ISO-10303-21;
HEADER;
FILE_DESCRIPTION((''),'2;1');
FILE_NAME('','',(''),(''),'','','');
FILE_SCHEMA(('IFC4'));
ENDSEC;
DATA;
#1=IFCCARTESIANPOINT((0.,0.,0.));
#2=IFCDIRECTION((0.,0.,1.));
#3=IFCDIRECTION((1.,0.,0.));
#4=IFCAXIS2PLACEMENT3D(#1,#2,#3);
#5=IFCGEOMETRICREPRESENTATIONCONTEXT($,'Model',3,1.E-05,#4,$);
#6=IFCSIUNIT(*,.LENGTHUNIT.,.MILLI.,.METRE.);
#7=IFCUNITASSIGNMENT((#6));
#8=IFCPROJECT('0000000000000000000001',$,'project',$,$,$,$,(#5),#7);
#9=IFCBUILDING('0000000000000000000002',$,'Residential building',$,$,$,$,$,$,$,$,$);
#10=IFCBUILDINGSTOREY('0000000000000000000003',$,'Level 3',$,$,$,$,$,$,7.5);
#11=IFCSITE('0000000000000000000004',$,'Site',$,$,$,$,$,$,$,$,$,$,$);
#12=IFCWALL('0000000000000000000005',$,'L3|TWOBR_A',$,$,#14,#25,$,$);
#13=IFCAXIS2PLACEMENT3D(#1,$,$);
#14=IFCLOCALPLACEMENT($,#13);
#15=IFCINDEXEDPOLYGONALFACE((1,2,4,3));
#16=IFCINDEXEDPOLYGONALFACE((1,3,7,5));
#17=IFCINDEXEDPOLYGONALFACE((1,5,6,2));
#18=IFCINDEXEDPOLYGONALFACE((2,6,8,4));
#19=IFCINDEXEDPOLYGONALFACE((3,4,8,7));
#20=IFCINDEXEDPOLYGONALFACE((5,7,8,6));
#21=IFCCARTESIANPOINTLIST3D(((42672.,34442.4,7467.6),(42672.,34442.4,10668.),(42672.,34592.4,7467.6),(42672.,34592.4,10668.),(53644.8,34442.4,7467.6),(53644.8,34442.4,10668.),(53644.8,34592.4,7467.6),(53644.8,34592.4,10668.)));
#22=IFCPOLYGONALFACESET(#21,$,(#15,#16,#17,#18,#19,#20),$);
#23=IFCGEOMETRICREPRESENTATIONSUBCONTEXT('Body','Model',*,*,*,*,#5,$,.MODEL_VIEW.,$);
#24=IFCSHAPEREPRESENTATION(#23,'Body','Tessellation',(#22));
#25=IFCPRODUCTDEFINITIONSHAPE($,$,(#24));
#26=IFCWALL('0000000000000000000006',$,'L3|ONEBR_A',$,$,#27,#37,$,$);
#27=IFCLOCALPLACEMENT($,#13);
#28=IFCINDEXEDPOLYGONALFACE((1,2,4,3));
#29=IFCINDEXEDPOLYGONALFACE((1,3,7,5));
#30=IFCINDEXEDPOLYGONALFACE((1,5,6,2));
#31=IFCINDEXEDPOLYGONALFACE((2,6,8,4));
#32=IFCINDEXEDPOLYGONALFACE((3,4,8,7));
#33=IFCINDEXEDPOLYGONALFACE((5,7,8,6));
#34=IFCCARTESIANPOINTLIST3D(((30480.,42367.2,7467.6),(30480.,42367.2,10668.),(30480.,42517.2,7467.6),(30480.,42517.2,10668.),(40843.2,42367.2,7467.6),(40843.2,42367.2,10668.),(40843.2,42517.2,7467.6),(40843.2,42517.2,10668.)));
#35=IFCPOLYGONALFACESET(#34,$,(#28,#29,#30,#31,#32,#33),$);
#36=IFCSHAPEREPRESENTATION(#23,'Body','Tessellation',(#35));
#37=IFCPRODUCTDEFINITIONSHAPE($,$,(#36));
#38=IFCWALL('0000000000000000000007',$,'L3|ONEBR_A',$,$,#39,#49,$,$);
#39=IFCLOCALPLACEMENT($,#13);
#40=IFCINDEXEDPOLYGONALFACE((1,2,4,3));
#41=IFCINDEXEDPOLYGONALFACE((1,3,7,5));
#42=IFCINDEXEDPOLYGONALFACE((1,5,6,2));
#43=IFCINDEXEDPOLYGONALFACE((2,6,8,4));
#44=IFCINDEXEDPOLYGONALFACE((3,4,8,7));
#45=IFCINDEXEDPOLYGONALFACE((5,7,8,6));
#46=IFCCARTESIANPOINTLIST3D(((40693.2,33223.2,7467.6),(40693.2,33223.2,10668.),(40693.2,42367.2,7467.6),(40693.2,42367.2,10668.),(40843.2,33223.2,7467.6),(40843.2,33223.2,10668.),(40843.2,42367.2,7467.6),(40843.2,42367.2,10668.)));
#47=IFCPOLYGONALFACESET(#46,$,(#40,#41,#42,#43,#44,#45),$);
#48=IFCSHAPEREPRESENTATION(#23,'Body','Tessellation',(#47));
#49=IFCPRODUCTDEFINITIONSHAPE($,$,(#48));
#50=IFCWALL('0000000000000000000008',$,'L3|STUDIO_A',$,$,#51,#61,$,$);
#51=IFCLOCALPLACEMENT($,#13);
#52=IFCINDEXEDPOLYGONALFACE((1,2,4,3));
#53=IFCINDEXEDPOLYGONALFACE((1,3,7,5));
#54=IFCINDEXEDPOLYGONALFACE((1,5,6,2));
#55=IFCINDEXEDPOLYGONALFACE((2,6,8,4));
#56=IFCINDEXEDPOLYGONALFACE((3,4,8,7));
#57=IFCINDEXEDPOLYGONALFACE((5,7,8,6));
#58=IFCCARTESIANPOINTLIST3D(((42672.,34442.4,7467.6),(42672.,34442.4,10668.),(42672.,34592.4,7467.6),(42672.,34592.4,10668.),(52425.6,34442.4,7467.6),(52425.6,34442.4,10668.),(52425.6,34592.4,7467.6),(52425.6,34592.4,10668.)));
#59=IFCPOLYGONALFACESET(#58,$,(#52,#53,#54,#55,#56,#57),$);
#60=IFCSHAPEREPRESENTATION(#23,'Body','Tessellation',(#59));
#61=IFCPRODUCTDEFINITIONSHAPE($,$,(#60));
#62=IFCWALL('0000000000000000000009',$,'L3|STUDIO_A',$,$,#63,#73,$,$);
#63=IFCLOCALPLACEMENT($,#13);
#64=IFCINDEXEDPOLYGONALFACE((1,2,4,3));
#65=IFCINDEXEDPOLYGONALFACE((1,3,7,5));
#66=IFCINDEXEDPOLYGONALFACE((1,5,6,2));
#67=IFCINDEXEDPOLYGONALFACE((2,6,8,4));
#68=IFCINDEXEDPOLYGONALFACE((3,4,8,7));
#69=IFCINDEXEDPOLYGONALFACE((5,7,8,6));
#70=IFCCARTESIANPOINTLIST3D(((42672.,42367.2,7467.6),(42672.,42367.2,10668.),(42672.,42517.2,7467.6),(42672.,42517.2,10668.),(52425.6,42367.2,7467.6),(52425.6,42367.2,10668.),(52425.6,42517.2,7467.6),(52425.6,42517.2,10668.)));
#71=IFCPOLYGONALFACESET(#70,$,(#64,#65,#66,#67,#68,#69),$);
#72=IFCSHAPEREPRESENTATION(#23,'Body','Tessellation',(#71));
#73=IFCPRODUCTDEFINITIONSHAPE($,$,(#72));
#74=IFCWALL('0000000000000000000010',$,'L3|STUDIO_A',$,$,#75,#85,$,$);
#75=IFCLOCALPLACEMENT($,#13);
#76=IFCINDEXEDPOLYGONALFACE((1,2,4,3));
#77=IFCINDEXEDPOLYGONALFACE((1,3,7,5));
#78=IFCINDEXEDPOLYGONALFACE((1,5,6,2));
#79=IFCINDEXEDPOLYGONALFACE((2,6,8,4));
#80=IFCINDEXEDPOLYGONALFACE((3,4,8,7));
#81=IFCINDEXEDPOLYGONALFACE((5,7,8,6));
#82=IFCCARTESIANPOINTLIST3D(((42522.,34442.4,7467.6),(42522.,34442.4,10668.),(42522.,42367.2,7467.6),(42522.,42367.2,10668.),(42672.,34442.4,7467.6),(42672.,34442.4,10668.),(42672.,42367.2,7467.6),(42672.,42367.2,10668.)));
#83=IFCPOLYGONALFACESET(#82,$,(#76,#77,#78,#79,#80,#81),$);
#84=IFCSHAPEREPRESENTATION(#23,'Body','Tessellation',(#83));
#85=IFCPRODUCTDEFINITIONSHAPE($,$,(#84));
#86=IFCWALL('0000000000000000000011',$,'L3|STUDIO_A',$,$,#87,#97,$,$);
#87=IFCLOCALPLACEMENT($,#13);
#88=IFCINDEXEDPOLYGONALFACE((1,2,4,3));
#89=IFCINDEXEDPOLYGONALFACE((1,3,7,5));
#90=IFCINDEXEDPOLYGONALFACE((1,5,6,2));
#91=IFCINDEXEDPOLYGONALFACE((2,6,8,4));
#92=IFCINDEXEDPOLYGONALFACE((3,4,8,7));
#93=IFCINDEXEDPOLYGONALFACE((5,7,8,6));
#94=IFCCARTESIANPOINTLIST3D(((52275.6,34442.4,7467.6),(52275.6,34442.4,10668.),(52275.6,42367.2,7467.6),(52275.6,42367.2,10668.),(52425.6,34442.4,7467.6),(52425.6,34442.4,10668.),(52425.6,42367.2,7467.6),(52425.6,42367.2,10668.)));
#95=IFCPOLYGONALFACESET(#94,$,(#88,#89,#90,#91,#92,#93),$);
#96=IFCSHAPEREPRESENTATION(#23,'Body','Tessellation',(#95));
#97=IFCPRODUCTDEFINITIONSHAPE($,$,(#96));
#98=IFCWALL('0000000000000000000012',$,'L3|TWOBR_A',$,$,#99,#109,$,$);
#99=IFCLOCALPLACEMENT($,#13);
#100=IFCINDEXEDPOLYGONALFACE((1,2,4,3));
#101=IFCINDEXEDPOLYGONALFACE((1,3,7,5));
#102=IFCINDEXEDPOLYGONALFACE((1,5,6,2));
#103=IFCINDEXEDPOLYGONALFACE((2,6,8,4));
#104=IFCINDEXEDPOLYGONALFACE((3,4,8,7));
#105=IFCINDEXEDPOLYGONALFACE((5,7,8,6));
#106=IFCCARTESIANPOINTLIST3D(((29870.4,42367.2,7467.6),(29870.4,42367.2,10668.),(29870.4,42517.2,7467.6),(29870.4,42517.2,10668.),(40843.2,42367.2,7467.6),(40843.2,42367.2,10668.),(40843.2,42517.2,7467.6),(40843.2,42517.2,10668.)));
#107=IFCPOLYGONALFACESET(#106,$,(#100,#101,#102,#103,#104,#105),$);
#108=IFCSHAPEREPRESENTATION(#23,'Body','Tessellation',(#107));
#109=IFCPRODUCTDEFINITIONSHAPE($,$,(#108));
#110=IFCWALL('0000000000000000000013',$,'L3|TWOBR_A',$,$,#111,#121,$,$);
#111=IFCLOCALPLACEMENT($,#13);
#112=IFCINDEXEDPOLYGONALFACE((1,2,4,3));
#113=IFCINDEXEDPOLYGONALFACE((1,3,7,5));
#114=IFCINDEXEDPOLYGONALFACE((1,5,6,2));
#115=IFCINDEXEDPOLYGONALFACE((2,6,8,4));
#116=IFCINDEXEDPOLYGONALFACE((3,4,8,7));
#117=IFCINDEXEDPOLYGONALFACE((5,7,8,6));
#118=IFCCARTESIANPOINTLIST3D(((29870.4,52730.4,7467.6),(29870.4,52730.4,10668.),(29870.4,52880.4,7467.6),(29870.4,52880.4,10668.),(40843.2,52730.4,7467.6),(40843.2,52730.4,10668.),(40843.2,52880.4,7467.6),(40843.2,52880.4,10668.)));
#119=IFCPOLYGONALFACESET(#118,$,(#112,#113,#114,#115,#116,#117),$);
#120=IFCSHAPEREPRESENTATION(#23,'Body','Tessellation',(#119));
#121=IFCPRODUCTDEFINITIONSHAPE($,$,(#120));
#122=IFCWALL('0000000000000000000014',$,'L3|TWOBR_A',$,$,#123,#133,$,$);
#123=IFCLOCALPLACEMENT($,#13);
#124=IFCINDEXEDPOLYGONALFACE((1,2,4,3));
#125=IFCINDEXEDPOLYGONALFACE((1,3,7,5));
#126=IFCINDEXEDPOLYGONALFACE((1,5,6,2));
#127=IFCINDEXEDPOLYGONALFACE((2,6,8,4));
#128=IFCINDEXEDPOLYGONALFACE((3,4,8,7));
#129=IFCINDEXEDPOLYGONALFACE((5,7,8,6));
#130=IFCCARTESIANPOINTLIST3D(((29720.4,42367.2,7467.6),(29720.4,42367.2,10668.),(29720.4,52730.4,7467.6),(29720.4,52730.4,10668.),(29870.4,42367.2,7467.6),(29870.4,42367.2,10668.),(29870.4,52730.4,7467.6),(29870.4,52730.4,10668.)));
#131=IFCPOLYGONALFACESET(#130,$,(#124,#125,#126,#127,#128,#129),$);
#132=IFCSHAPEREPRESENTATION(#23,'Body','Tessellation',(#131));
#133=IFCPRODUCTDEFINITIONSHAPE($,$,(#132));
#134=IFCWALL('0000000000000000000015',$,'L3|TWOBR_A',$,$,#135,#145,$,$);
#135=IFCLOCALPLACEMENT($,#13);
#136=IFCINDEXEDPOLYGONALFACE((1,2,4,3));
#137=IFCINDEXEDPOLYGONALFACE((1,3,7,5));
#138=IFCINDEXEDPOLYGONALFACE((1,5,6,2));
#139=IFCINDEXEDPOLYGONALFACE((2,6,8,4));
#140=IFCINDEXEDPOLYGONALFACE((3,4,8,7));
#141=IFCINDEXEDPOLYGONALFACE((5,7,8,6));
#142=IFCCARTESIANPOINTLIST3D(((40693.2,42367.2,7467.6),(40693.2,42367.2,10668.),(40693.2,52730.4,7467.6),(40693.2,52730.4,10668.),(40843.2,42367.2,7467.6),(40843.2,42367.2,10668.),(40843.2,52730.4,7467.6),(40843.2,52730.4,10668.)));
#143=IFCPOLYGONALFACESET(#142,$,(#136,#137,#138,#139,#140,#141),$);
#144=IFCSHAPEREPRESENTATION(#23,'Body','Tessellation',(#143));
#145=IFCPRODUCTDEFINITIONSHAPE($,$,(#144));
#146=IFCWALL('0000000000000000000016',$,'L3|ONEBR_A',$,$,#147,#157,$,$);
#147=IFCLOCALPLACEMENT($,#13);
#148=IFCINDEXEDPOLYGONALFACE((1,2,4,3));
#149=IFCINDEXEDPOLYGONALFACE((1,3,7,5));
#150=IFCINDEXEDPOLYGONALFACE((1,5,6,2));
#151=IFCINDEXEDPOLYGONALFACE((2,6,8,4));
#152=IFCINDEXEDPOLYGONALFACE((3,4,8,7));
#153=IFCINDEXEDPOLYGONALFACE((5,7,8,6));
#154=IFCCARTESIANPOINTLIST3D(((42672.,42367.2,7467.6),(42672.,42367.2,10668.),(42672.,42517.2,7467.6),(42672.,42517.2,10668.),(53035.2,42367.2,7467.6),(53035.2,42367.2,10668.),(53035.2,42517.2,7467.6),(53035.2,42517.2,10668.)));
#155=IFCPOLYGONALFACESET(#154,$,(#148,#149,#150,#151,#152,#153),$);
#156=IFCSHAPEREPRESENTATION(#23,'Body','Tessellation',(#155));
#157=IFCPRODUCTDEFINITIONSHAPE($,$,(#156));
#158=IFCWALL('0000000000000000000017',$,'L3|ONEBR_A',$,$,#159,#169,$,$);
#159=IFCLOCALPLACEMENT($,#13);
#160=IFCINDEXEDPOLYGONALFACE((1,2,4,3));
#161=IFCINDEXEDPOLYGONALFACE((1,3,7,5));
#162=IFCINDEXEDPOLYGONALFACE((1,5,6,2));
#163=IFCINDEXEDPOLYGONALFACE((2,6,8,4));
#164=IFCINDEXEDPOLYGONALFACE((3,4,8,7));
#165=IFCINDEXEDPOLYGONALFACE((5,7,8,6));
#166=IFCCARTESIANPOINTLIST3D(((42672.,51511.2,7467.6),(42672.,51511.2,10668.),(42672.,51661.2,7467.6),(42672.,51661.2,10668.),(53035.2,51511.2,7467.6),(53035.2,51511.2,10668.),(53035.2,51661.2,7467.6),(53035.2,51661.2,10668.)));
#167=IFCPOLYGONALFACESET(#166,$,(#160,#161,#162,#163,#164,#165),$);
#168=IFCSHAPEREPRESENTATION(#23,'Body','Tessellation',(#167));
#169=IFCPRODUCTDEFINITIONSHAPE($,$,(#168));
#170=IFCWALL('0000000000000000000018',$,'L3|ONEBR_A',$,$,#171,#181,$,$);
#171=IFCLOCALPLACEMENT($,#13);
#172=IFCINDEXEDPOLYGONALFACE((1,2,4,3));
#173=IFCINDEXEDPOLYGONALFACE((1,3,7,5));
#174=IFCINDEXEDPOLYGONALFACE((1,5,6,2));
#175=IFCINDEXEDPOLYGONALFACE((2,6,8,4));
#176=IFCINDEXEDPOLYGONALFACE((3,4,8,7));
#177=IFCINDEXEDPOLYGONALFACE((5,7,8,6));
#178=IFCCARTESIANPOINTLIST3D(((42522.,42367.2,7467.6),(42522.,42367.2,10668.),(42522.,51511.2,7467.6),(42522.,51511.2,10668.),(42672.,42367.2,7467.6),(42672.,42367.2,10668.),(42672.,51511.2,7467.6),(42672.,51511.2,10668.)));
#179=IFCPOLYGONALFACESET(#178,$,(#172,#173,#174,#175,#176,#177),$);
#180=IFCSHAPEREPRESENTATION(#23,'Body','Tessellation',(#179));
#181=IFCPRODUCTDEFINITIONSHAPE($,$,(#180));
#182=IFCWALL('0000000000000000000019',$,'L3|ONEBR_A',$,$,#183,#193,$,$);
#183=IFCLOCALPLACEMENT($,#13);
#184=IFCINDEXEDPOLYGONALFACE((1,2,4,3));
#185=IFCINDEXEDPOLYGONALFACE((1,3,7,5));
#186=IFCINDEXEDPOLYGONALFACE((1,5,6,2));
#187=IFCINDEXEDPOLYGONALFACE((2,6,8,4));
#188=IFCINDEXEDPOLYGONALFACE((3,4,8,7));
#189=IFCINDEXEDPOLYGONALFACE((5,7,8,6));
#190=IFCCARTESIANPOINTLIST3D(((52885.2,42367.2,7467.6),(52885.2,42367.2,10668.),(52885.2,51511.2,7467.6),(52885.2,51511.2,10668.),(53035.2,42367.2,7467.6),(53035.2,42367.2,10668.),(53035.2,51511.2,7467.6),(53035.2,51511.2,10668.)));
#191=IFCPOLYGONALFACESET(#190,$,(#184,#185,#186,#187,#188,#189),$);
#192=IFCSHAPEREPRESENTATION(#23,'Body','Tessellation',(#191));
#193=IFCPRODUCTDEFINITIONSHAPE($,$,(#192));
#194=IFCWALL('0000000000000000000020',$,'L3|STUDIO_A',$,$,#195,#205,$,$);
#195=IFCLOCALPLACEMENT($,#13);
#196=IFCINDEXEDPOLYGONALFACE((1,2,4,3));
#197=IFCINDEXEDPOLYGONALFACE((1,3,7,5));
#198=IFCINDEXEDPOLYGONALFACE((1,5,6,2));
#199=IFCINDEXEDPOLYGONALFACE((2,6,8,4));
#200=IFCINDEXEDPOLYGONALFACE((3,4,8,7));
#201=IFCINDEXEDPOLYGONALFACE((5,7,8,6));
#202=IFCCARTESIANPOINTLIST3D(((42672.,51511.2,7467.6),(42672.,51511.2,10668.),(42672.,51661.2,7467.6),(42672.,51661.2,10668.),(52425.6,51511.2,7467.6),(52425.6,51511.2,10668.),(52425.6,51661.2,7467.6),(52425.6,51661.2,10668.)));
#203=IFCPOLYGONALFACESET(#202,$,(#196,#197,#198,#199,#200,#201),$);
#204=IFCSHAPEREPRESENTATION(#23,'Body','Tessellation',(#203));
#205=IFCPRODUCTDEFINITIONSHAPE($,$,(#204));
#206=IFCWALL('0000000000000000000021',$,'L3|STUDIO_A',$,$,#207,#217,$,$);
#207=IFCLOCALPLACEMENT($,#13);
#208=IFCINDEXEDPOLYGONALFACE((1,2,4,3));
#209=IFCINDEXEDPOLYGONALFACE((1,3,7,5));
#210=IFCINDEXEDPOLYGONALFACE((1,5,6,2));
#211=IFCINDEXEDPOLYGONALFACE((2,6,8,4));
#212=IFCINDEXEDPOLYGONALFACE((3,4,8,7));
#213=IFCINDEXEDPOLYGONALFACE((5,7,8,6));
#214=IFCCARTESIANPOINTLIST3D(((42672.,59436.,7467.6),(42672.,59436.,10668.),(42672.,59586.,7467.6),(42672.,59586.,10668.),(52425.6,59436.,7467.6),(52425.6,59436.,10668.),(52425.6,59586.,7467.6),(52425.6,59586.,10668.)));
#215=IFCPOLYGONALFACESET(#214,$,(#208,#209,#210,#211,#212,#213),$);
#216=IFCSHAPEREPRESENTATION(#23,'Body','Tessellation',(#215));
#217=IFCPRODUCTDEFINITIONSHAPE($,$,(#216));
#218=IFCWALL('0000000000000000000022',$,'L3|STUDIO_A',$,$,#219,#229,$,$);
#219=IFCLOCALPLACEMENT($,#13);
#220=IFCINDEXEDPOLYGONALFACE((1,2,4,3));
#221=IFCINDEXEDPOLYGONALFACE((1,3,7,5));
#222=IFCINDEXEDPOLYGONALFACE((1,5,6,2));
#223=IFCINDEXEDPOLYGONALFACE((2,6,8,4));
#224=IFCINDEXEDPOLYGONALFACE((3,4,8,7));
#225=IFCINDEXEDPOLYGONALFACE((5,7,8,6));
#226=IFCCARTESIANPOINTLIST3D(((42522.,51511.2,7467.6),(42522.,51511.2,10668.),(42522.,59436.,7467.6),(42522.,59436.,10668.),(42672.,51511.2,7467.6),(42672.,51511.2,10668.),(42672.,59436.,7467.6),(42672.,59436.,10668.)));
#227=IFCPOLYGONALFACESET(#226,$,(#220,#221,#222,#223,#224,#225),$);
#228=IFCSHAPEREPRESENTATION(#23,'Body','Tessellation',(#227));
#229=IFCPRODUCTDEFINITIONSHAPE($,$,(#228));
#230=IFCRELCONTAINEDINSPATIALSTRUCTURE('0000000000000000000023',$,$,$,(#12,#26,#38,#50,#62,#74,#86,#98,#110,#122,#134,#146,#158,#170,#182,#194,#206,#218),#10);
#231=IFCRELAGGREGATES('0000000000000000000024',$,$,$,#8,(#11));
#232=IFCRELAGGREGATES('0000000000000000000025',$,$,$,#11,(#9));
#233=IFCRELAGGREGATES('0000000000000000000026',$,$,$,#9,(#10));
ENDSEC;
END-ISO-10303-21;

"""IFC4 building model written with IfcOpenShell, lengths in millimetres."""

from ifc_helpers import new_model, si_unit, frame, origin_with_axes, place, context, subcontext, project, spatial, indexed_curve, outline, extrude, element, save


model = new_model("IFC4")

# Units and contexts
model_context = context("Model", 3, precision=1e-05, world=origin_with_axes())
body_context = subcontext(model_context, "Body", "Model", "MODEL_VIEW")
ifc_project = project(units=[si_unit("LENGTHUNIT", "METRE", prefix="MILLI")], contexts=[model_context])

# Site, building, storey
site = spatial("IfcSite", under=ifc_project, Name="Site")
building = spatial("IfcBuilding", under=site, Name="Residential building")
storey = spatial("IfcBuildingStorey", under=building, Name="Level 3", Elevation=7.5)

# Walls
wall_1_placement = place(None, frame((42672.0, 34442.4, 7467.6), z_axis=(0.0, 0.0, 1.0), x_axis=(1.0, 0.0, 0.0)))
element("IfcWall", 1, at=wall_1_placement, inside=storey, Name="L3|TWOBR_A", context=body_context, shape_type="SweptSolid", body=[
    extrude(outline(indexed_curve([(0.0, 0.0), (0.0, 150.0), (10972.8, 150.0), (10972.8, 0.0), (0.0, 0.0)], self_intersect=False)), origin_with_axes(), (0.0, 0.0, 1.0), 3200.4),
])
wall_2_placement = place(None, frame((30480.0, 42367.2, 7467.6), z_axis=(0.0, 0.0, 1.0), x_axis=(1.0, 0.0, 0.0)))
element("IfcWall", 2, at=wall_2_placement, inside=storey, Name="L3|ONEBR_A", context=body_context, shape_type="SweptSolid", body=[
    extrude(outline(indexed_curve([(0.0, 0.0), (0.0, 150.0), (10363.2, 150.0), (10363.2, 0.0), (0.0, 0.0)], self_intersect=False)), origin_with_axes(), (0.0, 0.0, 1.0), 3200.4),
])
wall_3_placement = place(None, frame((40843.2, 33223.2, 7467.6), z_axis=(0.0, 0.0, 1.0), x_axis=(0.0, 1.0, 0.0)))
element("IfcWall", 3, at=wall_3_placement, inside=storey, Name="L3|ONEBR_A", context=body_context, shape_type="SweptSolid", body=[
    extrude(outline(indexed_curve([(0.0, 0.0), (0.0, 150.0), (9144.0, 150.0), (9144.0, 0.0), (0.0, 0.0)], self_intersect=False)), origin_with_axes(), (0.0, 0.0, 1.0), 3200.4),
])
for number, where, z_axis, x_axis, name in (
    (4, (42672.0, 34442.4, 7467.6), (0.0, 0.0, 1.0), (1.0, 0.0, 0.0), "L3|STUDIO_A"),
    (5, (42672.0, 42367.2, 7467.6), (0.0, 0.0, 1.0), (1.0, 0.0, 0.0), "L3|STUDIO_A"),
):
    element("IfcWall", number, at=place(None, frame(where, z_axis=z_axis, x_axis=x_axis)), inside=storey, Name=name, context=body_context, shape_type="SweptSolid", body=[
        extrude(outline(indexed_curve([(0.0, 0.0), (0.0, 150.0), (9753.6, 150.0), (9753.6, 0.0), (0.0, 0.0)], self_intersect=False)), origin_with_axes(), (0.0, 0.0, 1.0), 3200.4),
    ])
for number, where, z_axis, x_axis, name in (
    (6, (42672.0, 34442.4, 7467.6), (0.0, 0.0, 1.0), (0.0, 1.0, 0.0), "L3|STUDIO_A"),
    (7, (52425.6, 34442.4, 7467.6), (0.0, 0.0, 1.0), (0.0, 1.0, 0.0), "L3|STUDIO_A"),
):
    element("IfcWall", number, at=place(None, frame(where, z_axis=z_axis, x_axis=x_axis)), inside=storey, Name=name, context=body_context, shape_type="SweptSolid", body=[
        extrude(outline(indexed_curve([(0.0, 0.0), (0.0, 150.0), (7924.8, 150.0), (7924.8, 0.0), (0.0, 0.0)], self_intersect=False)), origin_with_axes(), (0.0, 0.0, 1.0), 3200.4),
    ])
for number, where, z_axis, x_axis, name in (
    (8, (29870.4, 42367.2, 7467.6), (0.0, 0.0, 1.0), (1.0, 0.0, 0.0), "L3|TWOBR_A"),
    (9, (29870.4, 52730.4, 7467.6), (0.0, 0.0, 1.0), (1.0, 0.0, 0.0), "L3|TWOBR_A"),
):
    element("IfcWall", number, at=place(None, frame(where, z_axis=z_axis, x_axis=x_axis)), inside=storey, Name=name, context=body_context, shape_type="SweptSolid", body=[
        extrude(outline(indexed_curve([(0.0, 0.0), (0.0, 150.0), (10972.8, 150.0), (10972.8, 0.0), (0.0, 0.0)], self_intersect=False)), origin_with_axes(), (0.0, 0.0, 1.0), 3200.4),
    ])
for number, where, z_axis, x_axis, name in (
    (10, (29870.4, 42367.2, 7467.6), (0.0, 0.0, 1.0), (0.0, 1.0, 0.0), "L3|TWOBR_A"),
    (11, (40843.2, 42367.2, 7467.6), (0.0, 0.0, 1.0), (0.0, 1.0, 0.0), "L3|TWOBR_A"),
    (12, (42672.0, 42367.2, 7467.6), (0.0, 0.0, 1.0), (1.0, 0.0, 0.0), "L3|ONEBR_A"),
    (13, (42672.0, 51511.2, 7467.6), (0.0, 0.0, 1.0), (1.0, 0.0, 0.0), "L3|ONEBR_A"),
):
    element("IfcWall", number, at=place(None, frame(where, z_axis=z_axis, x_axis=x_axis)), inside=storey, Name=name, context=body_context, shape_type="SweptSolid", body=[
        extrude(outline(indexed_curve([(0.0, 0.0), (0.0, 150.0), (10363.2, 150.0), (10363.2, 0.0), (0.0, 0.0)], self_intersect=False)), origin_with_axes(), (0.0, 0.0, 1.0), 3200.4),
    ])
for number, where, z_axis, x_axis, name in (
    (14, (42672.0, 42367.2, 7467.6), (0.0, 0.0, 1.0), (0.0, 1.0, 0.0), "L3|ONEBR_A"),
    (15, (53035.2, 42367.2, 7467.6), (0.0, 0.0, 1.0), (0.0, 1.0, 0.0), "L3|ONEBR_A"),
):
    element("IfcWall", number, at=place(None, frame(where, z_axis=z_axis, x_axis=x_axis)), inside=storey, Name=name, context=body_context, shape_type="SweptSolid", body=[
        extrude(outline(indexed_curve([(0.0, 0.0), (0.0, 150.0), (9144.0, 150.0), (9144.0, 0.0), (0.0, 0.0)], self_intersect=False)), origin_with_axes(), (0.0, 0.0, 1.0), 3200.4),
    ])
for number, where, z_axis, x_axis, name in (
    (16, (42672.0, 51511.2, 7467.6), (0.0, 0.0, 1.0), (1.0, 0.0, 0.0), "L3|STUDIO_A"),
    (17, (42672.0, 59436.0, 7467.6), (0.0, 0.0, 1.0), (1.0, 0.0, 0.0), "L3|STUDIO_A"),
):
    element("IfcWall", number, at=place(None, frame(where, z_axis=z_axis, x_axis=x_axis)), inside=storey, Name=name, context=body_context, shape_type="SweptSolid", body=[
        extrude(outline(indexed_curve([(0.0, 0.0), (0.0, 150.0), (9753.6, 150.0), (9753.6, 0.0), (0.0, 0.0)], self_intersect=False)), origin_with_axes(), (0.0, 0.0, 1.0), 3200.4),
    ])
for number, where, z_axis, x_axis, name in (
    (18, (42672.0, 51511.2, 7467.6), (0.0, 0.0, 1.0), (0.0, 1.0, 0.0), "L3|STUDIO_A"),
):
    element("IfcWall", number, at=place(None, frame(where, z_axis=z_axis, x_axis=x_axis)), inside=storey, Name=name, context=body_context, shape_type="SweptSolid", body=[
        extrude(outline(indexed_curve([(0.0, 0.0), (0.0, 150.0), (7924.8, 150.0), (7924.8, 0.0), (0.0, 0.0)], self_intersect=False)), origin_with_axes(), (0.0, 0.0, 1.0), 3200.4),
    ])

save(model, "model.ifc")
